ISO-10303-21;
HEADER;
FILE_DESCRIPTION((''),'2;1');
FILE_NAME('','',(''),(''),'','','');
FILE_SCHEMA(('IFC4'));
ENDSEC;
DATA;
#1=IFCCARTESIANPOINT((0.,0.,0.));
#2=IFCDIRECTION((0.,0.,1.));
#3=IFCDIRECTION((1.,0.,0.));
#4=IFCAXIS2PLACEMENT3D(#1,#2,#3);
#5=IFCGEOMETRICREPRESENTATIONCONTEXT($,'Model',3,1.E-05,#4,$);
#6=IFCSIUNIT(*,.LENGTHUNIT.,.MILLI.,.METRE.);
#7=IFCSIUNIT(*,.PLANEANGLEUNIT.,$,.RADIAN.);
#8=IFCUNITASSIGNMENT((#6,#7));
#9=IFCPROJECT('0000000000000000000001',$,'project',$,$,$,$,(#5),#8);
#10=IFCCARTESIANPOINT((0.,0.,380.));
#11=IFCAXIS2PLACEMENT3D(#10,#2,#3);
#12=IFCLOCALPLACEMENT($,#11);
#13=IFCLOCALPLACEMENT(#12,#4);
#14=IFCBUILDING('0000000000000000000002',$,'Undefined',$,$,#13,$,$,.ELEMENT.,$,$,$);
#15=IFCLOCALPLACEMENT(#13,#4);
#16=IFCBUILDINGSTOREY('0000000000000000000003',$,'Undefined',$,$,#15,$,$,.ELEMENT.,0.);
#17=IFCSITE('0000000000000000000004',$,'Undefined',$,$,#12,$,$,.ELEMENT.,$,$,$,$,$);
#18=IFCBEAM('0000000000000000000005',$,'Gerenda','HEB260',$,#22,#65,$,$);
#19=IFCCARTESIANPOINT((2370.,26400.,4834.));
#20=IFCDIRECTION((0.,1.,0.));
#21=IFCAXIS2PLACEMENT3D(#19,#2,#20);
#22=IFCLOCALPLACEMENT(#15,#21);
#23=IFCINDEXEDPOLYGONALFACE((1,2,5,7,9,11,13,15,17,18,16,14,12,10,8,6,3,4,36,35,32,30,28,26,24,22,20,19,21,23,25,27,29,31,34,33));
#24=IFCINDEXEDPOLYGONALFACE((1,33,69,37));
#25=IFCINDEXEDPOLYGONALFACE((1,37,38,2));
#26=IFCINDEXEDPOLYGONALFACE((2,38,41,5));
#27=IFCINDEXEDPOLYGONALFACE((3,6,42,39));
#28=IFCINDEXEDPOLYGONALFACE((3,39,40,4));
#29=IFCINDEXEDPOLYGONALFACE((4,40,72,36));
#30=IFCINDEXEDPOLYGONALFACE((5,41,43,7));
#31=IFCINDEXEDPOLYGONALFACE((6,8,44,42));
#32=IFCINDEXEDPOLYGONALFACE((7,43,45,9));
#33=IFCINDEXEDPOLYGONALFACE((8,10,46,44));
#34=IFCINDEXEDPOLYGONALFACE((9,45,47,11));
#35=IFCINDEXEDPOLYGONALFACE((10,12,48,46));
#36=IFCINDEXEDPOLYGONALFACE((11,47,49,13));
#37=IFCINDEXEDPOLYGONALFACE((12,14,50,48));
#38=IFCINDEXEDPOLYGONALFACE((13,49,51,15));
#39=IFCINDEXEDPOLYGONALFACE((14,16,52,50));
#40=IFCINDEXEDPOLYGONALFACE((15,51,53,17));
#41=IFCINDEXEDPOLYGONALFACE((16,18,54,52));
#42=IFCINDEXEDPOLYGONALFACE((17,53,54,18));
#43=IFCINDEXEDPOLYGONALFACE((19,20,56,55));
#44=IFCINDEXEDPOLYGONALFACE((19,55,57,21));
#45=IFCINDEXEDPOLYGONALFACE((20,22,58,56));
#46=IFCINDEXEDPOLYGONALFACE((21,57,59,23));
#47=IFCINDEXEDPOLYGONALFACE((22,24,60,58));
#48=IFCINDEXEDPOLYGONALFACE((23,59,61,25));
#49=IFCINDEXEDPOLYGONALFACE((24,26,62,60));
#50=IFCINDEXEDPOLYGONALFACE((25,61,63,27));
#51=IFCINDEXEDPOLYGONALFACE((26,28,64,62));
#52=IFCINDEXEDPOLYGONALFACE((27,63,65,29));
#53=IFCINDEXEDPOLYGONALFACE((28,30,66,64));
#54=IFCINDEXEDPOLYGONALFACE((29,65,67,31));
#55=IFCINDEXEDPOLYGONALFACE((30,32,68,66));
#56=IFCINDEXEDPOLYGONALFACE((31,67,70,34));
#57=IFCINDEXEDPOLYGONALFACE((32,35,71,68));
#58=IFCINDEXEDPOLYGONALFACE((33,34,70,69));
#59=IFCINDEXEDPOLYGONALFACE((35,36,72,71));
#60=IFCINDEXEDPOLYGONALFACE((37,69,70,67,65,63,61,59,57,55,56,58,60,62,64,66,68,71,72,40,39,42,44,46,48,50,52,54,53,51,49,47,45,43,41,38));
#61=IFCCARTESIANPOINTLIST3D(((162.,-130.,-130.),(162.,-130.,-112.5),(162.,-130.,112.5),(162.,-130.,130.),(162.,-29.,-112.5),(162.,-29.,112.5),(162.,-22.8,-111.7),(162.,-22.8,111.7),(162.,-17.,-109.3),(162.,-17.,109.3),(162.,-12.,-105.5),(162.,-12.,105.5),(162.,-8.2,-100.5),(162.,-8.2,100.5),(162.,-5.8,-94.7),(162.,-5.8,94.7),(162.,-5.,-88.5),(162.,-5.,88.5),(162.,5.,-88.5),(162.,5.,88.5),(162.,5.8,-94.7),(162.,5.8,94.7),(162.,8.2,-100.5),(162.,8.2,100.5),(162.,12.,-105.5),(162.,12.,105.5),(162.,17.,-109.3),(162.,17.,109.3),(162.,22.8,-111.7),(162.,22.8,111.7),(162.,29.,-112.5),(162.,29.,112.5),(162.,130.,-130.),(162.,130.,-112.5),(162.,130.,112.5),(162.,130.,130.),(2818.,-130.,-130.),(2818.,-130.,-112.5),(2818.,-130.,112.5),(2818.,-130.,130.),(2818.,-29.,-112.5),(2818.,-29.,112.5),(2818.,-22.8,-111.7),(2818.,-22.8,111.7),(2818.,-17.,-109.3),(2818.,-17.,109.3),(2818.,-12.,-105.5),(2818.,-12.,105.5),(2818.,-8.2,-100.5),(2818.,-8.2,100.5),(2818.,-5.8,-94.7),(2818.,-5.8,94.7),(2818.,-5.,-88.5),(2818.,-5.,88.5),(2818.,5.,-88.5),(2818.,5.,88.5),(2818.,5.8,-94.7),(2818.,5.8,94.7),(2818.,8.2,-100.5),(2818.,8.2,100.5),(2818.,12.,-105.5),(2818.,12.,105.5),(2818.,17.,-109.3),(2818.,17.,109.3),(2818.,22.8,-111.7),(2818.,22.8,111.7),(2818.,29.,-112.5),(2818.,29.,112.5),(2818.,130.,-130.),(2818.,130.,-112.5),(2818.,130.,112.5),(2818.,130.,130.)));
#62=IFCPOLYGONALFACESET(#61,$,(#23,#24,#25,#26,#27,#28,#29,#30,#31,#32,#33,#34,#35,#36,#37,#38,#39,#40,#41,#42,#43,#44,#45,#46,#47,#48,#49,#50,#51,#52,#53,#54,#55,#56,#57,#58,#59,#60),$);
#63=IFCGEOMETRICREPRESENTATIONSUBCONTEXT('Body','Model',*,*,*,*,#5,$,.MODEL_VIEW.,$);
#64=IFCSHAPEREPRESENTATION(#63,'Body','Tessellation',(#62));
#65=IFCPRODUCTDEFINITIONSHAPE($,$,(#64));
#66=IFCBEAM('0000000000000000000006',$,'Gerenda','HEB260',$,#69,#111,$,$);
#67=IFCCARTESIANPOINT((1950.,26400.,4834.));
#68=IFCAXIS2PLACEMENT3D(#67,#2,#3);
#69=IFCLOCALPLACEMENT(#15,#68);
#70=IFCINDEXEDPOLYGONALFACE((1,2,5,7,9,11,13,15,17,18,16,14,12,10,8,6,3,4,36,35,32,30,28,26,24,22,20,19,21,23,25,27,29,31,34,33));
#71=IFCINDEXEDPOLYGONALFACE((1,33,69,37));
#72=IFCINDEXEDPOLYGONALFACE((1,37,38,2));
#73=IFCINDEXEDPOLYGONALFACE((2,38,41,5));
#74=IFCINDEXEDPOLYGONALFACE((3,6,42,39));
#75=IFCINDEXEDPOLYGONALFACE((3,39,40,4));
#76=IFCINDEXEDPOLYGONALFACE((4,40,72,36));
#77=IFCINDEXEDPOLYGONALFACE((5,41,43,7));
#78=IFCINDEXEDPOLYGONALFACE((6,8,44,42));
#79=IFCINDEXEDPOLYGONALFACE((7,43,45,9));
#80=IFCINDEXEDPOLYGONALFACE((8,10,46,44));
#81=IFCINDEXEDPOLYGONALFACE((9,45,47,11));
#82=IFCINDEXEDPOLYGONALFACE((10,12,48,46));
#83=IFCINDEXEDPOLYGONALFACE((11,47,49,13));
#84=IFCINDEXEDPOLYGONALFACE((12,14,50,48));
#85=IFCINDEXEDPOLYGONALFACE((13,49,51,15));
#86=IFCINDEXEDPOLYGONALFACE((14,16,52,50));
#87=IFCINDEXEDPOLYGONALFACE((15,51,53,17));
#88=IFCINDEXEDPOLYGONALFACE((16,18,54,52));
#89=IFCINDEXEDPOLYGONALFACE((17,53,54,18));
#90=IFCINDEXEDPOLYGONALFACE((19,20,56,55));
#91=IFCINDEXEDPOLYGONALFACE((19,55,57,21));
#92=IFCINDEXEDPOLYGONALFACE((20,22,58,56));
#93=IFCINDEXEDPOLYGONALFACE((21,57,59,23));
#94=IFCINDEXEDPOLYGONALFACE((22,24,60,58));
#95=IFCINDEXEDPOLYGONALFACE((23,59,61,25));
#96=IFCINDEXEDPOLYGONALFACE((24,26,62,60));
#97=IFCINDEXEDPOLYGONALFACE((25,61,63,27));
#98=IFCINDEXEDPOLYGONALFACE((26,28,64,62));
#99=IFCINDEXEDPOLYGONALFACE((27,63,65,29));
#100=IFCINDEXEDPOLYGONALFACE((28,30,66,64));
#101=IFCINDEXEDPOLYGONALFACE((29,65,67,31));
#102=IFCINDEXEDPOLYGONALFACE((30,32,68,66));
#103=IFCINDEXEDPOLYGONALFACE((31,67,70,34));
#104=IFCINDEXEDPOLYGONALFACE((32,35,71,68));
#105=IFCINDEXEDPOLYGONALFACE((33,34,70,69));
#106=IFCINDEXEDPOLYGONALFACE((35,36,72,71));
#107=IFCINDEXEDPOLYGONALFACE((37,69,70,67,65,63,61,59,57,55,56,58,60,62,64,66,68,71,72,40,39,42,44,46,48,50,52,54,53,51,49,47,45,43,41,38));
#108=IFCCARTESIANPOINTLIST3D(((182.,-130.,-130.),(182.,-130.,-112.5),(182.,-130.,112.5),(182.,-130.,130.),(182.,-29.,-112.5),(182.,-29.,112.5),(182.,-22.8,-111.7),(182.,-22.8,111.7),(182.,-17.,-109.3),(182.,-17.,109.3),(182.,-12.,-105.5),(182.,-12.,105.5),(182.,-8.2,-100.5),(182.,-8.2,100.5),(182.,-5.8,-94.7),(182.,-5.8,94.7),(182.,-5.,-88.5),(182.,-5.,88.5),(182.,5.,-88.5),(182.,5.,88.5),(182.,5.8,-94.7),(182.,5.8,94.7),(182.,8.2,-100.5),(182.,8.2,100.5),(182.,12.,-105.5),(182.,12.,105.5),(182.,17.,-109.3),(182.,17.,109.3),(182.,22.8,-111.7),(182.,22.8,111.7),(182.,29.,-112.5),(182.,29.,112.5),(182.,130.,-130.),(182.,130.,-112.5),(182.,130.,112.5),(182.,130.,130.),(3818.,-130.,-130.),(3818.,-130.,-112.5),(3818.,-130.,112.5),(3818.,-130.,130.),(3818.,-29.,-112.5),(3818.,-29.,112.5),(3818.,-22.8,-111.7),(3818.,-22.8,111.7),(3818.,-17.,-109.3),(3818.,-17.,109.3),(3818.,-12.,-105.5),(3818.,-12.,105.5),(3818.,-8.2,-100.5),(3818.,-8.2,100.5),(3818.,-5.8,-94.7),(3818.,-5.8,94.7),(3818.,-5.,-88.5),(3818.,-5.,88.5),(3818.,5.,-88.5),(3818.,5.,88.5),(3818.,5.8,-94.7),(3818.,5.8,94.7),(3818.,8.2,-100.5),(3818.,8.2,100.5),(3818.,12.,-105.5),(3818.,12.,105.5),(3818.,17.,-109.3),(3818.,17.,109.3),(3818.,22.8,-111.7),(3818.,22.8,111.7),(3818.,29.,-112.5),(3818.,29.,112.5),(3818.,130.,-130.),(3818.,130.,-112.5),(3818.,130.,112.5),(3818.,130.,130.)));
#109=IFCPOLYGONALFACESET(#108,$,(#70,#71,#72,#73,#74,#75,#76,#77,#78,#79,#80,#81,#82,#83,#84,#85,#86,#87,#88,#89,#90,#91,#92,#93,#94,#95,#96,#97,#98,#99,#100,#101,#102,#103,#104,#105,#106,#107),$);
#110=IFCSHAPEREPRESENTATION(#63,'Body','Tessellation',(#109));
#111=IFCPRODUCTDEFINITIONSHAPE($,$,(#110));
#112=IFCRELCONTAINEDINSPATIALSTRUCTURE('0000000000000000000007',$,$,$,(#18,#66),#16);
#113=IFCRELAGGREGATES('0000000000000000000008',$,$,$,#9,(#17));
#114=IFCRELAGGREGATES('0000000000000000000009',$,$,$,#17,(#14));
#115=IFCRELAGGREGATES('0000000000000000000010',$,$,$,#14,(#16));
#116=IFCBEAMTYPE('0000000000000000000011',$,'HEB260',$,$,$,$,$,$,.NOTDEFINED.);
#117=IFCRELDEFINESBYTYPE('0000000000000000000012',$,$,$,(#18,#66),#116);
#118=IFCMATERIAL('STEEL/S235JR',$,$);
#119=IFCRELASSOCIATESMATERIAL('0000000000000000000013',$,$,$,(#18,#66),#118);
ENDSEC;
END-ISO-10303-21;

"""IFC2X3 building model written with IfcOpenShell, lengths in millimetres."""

from ifc_helpers import new_model, si_unit, frame, origin_with_axes, origin_2d_with_axis, place, context, subcontext, project, spatial, i_section, extrude, clip, halfspace, material, type_object, element, save


model = new_model("IFC2X3")

# Units and contexts
model_context = context("Model", 3, precision=1e-05, world=origin_with_axes())
body_context = subcontext(model_context, "Body", "Model", "MODEL_VIEW")
ifc_project = project(units=[si_unit("LENGTHUNIT", "METRE", prefix="MILLI"), si_unit("PLANEANGLEUNIT", "RADIAN")], contexts=[model_context])

# Site, building, storey
site_placement = place(None, frame((0.0, 0.0, 380.0), z_axis=(0.0, 0.0, 1.0), x_axis=(1.0, 0.0, 0.0)))
site = spatial("IfcSite", under=ifc_project, at=site_placement, Name="Undefined", CompositionType="ELEMENT")
building_placement = place(site_placement, origin_with_axes())
building = spatial("IfcBuilding", under=site, at=building_placement, Name="Undefined", CompositionType="ELEMENT")
storey_placement = place(building_placement, origin_with_axes())
storey = spatial("IfcBuildingStorey", under=building, at=storey_placement, Name="Undefined", CompositionType="ELEMENT", Elevation=0.0)

# Shared definitions
ifc_material = material(Name="STEEL/S235JR")

# Beams
beam_type = type_object("IfcBeamType", Name="HEB260", PredefinedType="NOTDEFINED")
beam_1_placement = place(storey_placement, frame((2370.0, 26400.0, 4834.0), z_axis=(0.0, 0.0, 1.0), x_axis=(0.0, 1.0, 0.0)))
element("IfcBeam", 1, at=beam_1_placement, inside=storey, type_object=beam_type, material=ifc_material, Name="Gerenda", Description="HEB260", context=body_context, shape_type="Clipping", body=[
    clip(clip(extrude(i_section(OverallWidth=260.0, OverallDepth=260.0, WebThickness=10.0, FlangeThickness=17.5, FilletRadius=24.0, at=origin_2d_with_axis()), frame((3000.0, 0.0, 0.0), z_axis=(-1.0, 0.0, 0.0), x_axis=(0.0, -1.0, 0.0)), (0.0, 0.0, 1.0), 3000.0), halfspace(frame((2818.0, 0.0, -130.0), z_axis=(-1.0, 0.0, 0.0), x_axis=(0.0, 1.0, 0.0)), True)), halfspace(frame((162.0, 0.0, -130.0), z_axis=(1.0, 0.0, 0.0), x_axis=(0.0, -1.0, 0.0)), True)),
])
beam_2_placement = place(storey_placement, frame((1950.0, 26400.0, 4834.0), z_axis=(0.0, 0.0, 1.0), x_axis=(1.0, 0.0, 0.0)))
element("IfcBeam", 2, at=beam_2_placement, inside=storey, type_object=beam_type, material=ifc_material, Name="Gerenda", Description="HEB260", context=body_context, shape_type="Clipping", body=[
    clip(clip(extrude(i_section(OverallWidth=260.0, OverallDepth=260.0, WebThickness=10.0, FlangeThickness=17.5, FilletRadius=24.0, at=origin_2d_with_axis()), frame((4000.0, 0.0, 0.0), z_axis=(-1.0, 0.0, 0.0), x_axis=(0.0, -1.0, 0.0)), (0.0, 0.0, 1.0), 4000.0), halfspace(frame((3818.0, 0.0, -130.0), z_axis=(-1.0, 0.0, 0.0), x_axis=(0.0, 1.0, 0.0)), True)), halfspace(frame((182.0, 0.0, -130.0), z_axis=(1.0, 0.0, 0.0), x_axis=(0.0, -1.0, 0.0)), True)),
])

save(model, "model.ifc")
